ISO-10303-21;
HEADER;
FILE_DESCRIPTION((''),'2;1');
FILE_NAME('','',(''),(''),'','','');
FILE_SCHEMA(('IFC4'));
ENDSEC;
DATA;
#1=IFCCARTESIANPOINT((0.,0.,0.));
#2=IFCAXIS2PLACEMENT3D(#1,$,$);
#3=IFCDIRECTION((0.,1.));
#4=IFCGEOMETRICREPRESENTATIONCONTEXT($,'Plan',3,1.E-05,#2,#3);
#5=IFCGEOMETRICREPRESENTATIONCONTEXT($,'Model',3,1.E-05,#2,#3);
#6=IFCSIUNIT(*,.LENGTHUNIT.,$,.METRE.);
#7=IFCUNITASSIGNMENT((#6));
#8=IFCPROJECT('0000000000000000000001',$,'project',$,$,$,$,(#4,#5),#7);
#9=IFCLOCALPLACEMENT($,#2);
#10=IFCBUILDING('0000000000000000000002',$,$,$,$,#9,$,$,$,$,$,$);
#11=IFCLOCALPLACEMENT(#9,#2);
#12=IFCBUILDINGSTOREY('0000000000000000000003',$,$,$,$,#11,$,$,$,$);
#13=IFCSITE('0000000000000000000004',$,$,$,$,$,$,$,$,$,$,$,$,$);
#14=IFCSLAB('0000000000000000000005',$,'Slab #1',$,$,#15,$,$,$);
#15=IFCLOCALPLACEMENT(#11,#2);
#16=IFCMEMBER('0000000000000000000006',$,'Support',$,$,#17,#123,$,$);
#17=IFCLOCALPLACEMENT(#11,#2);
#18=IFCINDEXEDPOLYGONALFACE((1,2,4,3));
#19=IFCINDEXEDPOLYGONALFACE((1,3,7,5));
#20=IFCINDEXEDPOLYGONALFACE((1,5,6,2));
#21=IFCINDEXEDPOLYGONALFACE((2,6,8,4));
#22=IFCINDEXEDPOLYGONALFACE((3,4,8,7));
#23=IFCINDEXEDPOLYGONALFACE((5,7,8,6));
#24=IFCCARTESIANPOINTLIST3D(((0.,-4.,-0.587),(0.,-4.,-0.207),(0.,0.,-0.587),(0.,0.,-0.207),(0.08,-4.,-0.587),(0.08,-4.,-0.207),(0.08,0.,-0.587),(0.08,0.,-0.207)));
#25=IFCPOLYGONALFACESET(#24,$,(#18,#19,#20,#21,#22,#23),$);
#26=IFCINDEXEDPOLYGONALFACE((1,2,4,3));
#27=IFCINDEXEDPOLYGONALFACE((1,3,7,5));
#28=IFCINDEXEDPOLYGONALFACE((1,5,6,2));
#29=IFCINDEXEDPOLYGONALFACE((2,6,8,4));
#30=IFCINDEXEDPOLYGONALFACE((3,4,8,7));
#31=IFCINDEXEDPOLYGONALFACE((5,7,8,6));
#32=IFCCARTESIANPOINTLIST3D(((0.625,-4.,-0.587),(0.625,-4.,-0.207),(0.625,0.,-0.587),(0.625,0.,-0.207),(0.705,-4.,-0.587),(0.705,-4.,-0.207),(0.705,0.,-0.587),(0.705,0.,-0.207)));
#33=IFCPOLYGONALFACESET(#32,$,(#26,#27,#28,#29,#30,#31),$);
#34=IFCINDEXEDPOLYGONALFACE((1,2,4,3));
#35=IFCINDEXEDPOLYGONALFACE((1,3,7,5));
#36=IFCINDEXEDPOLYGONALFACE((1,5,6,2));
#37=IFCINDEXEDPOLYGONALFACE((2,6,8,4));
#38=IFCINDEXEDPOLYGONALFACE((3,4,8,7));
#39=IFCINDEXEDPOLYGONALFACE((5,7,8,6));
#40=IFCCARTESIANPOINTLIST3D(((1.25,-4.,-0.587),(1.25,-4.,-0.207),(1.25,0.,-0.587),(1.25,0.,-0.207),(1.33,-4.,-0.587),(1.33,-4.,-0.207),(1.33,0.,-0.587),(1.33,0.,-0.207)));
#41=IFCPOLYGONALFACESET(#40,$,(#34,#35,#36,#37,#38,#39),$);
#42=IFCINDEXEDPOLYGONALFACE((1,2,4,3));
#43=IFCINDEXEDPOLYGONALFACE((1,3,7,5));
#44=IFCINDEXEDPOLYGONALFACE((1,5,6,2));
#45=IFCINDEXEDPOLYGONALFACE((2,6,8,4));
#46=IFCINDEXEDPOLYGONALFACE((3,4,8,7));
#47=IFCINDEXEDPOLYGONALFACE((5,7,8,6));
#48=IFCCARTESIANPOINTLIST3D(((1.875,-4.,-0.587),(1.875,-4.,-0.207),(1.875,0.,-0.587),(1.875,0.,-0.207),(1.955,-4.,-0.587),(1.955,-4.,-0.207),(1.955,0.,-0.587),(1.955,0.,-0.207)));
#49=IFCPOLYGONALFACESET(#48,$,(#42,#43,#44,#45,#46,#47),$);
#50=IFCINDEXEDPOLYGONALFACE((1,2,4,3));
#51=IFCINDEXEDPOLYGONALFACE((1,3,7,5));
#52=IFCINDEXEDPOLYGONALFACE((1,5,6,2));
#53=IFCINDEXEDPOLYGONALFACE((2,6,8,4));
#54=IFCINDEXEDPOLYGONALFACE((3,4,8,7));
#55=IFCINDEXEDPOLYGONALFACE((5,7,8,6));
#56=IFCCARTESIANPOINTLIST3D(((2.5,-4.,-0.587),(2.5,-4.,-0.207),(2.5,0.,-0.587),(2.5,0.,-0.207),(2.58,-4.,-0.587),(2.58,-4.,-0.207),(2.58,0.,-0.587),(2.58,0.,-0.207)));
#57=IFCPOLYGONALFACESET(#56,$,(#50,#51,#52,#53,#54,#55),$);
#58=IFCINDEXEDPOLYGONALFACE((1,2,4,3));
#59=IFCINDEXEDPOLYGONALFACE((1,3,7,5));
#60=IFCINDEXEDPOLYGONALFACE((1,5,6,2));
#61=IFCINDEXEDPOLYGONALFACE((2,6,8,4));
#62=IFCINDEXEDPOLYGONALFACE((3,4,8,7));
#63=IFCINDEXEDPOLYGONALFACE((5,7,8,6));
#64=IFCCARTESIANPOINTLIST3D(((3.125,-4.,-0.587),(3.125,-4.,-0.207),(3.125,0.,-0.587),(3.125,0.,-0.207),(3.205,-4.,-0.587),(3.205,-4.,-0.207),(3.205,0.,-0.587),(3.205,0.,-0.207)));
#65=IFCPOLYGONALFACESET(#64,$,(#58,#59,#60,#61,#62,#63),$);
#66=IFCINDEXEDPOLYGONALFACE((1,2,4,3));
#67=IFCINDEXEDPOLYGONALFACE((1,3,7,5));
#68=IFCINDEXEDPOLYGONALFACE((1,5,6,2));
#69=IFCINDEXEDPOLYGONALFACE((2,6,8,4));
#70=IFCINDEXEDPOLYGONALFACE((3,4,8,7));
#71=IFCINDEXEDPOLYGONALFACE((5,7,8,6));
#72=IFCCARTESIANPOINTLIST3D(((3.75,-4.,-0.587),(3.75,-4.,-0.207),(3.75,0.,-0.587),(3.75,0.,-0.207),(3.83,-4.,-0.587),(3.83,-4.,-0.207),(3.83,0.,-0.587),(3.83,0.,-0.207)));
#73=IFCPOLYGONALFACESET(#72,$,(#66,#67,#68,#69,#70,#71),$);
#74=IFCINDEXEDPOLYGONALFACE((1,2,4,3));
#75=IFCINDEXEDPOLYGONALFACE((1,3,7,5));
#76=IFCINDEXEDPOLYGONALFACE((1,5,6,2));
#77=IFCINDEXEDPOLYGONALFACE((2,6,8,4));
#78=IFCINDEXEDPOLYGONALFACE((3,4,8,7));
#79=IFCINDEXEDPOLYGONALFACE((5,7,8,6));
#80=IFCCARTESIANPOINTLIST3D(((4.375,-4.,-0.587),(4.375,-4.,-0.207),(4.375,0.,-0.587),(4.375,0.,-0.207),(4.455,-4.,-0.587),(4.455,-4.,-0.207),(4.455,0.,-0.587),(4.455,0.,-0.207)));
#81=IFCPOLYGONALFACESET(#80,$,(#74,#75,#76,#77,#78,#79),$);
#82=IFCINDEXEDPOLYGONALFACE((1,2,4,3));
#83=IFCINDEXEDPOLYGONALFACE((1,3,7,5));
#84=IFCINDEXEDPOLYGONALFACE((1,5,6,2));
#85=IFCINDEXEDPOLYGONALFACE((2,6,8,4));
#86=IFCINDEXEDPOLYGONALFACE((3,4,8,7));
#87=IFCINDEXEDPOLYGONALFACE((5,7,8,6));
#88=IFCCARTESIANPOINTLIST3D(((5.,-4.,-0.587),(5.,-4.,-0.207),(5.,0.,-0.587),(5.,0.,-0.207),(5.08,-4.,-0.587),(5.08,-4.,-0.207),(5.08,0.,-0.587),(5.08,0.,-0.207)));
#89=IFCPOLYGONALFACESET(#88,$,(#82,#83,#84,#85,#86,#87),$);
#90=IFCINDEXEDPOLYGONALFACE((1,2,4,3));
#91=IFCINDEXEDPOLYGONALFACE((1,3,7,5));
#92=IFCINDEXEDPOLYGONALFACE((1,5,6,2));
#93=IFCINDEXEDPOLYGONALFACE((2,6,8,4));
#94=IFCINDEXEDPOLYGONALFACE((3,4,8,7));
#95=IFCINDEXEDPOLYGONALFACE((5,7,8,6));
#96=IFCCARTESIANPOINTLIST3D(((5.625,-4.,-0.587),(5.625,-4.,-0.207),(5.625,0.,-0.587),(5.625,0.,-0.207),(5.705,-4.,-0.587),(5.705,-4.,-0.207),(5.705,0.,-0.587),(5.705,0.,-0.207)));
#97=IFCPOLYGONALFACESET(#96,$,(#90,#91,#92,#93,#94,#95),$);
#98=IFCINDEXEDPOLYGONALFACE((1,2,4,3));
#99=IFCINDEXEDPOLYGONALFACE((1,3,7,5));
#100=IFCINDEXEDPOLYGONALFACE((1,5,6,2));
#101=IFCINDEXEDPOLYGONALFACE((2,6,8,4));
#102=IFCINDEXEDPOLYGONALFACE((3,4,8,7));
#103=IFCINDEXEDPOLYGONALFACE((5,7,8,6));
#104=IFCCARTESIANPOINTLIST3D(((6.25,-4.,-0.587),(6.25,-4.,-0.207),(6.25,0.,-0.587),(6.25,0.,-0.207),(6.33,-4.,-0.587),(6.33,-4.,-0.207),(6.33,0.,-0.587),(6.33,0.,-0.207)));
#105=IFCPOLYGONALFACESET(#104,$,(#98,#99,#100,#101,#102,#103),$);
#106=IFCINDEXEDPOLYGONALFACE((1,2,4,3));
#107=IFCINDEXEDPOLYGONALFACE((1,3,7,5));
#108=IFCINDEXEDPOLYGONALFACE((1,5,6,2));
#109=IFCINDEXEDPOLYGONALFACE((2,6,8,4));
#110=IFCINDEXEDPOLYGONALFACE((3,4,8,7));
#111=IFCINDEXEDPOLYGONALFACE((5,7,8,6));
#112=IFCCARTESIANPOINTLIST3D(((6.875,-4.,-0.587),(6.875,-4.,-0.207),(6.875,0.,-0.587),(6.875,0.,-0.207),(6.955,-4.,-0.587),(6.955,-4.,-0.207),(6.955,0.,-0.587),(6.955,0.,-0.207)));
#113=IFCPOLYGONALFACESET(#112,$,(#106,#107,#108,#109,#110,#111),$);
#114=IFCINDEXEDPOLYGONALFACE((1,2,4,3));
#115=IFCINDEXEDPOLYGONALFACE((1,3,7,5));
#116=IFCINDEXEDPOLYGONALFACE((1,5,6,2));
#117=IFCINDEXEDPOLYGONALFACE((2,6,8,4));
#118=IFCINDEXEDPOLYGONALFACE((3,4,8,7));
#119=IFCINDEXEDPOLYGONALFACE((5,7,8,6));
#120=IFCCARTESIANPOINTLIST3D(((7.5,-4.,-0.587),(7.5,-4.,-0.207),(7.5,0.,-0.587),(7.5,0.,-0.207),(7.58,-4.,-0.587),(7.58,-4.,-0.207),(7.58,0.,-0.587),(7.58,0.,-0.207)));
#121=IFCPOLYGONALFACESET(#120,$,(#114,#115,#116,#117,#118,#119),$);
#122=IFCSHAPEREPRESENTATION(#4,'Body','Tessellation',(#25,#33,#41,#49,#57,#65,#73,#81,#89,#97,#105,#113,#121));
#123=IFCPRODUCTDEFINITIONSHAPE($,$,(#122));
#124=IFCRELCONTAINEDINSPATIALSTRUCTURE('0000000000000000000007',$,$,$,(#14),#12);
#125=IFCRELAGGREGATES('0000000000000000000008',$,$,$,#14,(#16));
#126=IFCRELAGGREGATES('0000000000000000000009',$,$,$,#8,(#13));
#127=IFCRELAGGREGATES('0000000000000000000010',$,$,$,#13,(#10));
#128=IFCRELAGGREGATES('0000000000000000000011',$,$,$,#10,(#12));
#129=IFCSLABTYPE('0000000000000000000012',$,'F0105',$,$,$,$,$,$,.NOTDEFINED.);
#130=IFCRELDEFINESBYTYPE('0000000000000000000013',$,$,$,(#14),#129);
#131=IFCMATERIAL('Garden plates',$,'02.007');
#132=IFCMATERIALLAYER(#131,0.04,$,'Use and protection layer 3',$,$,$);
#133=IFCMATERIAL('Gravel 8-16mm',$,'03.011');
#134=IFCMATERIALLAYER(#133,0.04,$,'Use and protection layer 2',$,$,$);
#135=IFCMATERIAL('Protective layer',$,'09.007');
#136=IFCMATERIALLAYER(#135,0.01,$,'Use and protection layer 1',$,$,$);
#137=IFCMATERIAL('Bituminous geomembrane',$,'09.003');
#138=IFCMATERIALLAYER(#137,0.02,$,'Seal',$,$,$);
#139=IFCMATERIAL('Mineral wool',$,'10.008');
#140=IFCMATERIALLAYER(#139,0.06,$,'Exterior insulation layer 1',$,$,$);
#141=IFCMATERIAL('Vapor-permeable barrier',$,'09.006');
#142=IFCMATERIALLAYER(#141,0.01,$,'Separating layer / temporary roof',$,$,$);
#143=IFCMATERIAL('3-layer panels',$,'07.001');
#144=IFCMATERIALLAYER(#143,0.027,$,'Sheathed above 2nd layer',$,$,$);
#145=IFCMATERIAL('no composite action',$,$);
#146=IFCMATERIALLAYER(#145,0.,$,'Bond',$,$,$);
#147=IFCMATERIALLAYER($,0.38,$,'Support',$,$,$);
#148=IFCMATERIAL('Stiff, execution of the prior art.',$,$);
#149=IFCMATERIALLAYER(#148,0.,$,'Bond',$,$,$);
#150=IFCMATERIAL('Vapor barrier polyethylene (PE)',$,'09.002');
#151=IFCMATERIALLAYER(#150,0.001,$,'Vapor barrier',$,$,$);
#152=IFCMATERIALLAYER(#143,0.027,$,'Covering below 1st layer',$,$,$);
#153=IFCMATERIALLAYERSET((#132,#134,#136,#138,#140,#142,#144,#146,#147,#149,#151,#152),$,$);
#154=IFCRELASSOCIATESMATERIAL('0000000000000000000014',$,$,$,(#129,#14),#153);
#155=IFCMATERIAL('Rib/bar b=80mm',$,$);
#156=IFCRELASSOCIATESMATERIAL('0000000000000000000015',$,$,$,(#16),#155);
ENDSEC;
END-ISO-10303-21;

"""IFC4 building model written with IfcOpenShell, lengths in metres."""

from ifc_helpers import new_model, si_unit, direction, frame, frame_2d, origin, place, context, project, spatial, rectangle, extrude, material, layer, layer_set, type_object, element, aggregate, save


model = new_model("IFC4")

# Units and contexts
plan_context = context("Plan", 3, precision=1e-05, world=origin(), true_north=direction((0.0, 1.0)))
model_context = context("Model", 3, precision=1e-05, world=origin(), true_north=direction((0.0, 1.0)))
ifc_project = project(units=[si_unit("LENGTHUNIT", "METRE")], contexts=[plan_context, model_context])

# Site, building, storey
site = spatial("IfcSite", under=ifc_project)
building_placement = place(None, origin())
building = spatial("IfcBuilding", under=site, at=building_placement)
storey_placement = place(building_placement, origin())
storey = spatial("IfcBuildingStorey", under=building, at=storey_placement)

# Slab, member
ifc_material_1 = material(Name="Garden plates", Category="02.007")
ifc_layer_1 = layer(ifc_material_1, 0.04, Name="Use and protection layer 3")
ifc_material_2 = material(Name="Gravel 8-16mm", Category="03.011")
ifc_layer_2 = layer(ifc_material_2, 0.04, Name="Use and protection layer 2")
ifc_material_3 = material(Name="Protective layer", Category="09.007")
ifc_layer_3 = layer(ifc_material_3, 0.01, Name="Use and protection layer 1")
ifc_material_4 = material(Name="Bituminous geomembrane", Category="09.003")
ifc_layer_4 = layer(ifc_material_4, 0.02, Name="Seal")
ifc_material_5 = material(Name="Mineral wool", Category="10.008")
ifc_layer_5 = layer(ifc_material_5, 0.06, Name="Exterior insulation layer 1")
ifc_material_6 = material(Name="Vapor-permeable barrier", Category="09.006")
ifc_layer_6 = layer(ifc_material_6, 0.01, Name="Separating layer / temporary roof")
ifc_material_7 = material(Name="3-layer panels", Category="07.001")
ifc_layer_7 = layer(ifc_material_7, 0.027, Name="Sheathed above 2nd layer")
ifc_material_8 = material(Name="no composite action")
ifc_layer_8 = layer(ifc_material_8, 0.0, Name="Bond")
ifc_layer_9 = layer(None, 0.38, Name="Support")
ifc_material_9 = material(Name="Stiff, execution of the prior art.")
ifc_layer_10 = layer(ifc_material_9, 0.0, Name="Bond")
ifc_material_10 = material(Name="Vapor barrier polyethylene (PE)", Category="09.002")
ifc_layer_11 = layer(ifc_material_10, 0.001, Name="Vapor barrier")
ifc_layer_12 = layer(ifc_material_7, 0.027, Name="Covering below 1st layer")
ifc_layer_set = layer_set([ifc_layer_1, ifc_layer_2, ifc_layer_3, ifc_layer_4, ifc_layer_5, ifc_layer_6, ifc_layer_7, ifc_layer_8, ifc_layer_9, ifc_layer_10, ifc_layer_11, ifc_layer_12])
slab_type = type_object("IfcSlabType", Name="F0105", PredefinedType="NOTDEFINED", material=ifc_layer_set)
slab_placement = place(None, frame((0.0, 0.0, 0.0), z_axis=(0.0, 0.0, -1.0), x_axis=(1.0, 0.0, 0.0)))
slab = element("IfcSlab", 1, at=slab_placement, inside=storey, type_object=slab_type, material=ifc_layer_set, Name="Slab #1")
ifc_material_11 = material(Name="Rib/bar b=80mm")
member_1_placement = place(slab_placement, origin())
member_1 = element("IfcMember", 2, at=member_1_placement, material=ifc_material_11, Name="Support", context=plan_context, shape_type="SweptSolid", body=[
    extrude(rectangle(XDim=0.08, YDim=0.38, at=frame_2d((0.04, 0.19), x_axis=(1.0, 0.0))), frame((0.0, 4.0, 0.207), z_axis=(0.0, -1.0, 0.0), x_axis=(1.0, 0.0, 0.0)), (0.0, 0.0, 1.0), 4.0),
    extrude(rectangle(XDim=0.08, YDim=0.38, at=frame_2d((0.04, 0.19), x_axis=(1.0, 0.0))), frame((0.625, 4.0, 0.207), z_axis=(0.0, -1.0, 0.0), x_axis=(1.0, 0.0, 0.0)), (0.0, 0.0, 1.0), 4.0),
    extrude(rectangle(XDim=0.08, YDim=0.38, at=frame_2d((0.04, 0.19), x_axis=(1.0, 0.0))), frame((1.25, 4.0, 0.207), z_axis=(0.0, -1.0, 0.0), x_axis=(1.0, 0.0, 0.0)), (0.0, 0.0, 1.0), 4.0),
    extrude(rectangle(XDim=0.08, YDim=0.38, at=frame_2d((0.04, 0.19), x_axis=(1.0, 0.0))), frame((1.875, 4.0, 0.207), z_axis=(0.0, -1.0, 0.0), x_axis=(1.0, 0.0, 0.0)), (0.0, 0.0, 1.0), 4.0),
    extrude(rectangle(XDim=0.08, YDim=0.38, at=frame_2d((0.04, 0.19), x_axis=(1.0, 0.0))), frame((2.5, 4.0, 0.207), z_axis=(0.0, -1.0, 0.0), x_axis=(1.0, 0.0, 0.0)), (0.0, 0.0, 1.0), 4.0),
    extrude(rectangle(XDim=0.08, YDim=0.38, at=frame_2d((0.04, 0.19), x_axis=(1.0, 0.0))), frame((3.125, 4.0, 0.207), z_axis=(0.0, -1.0, 0.0), x_axis=(1.0, 0.0, 0.0)), (0.0, 0.0, 1.0), 4.0),
    extrude(rectangle(XDim=0.08, YDim=0.38, at=frame_2d((0.04, 0.19), x_axis=(1.0, 0.0))), frame((3.75, 4.0, 0.207), z_axis=(0.0, -1.0, 0.0), x_axis=(1.0, 0.0, 0.0)), (0.0, 0.0, 1.0), 4.0),
    extrude(rectangle(XDim=0.08, YDim=0.38, at=frame_2d((0.04, 0.19), x_axis=(1.0, 0.0))), frame((4.375, 4.0, 0.207), z_axis=(0.0, -1.0, 0.0), x_axis=(1.0, 0.0, 0.0)), (0.0, 0.0, 1.0), 4.0),
    extrude(rectangle(XDim=0.08, YDim=0.38, at=frame_2d((0.04, 0.19), x_axis=(1.0, 0.0))), frame((5.0, 4.0, 0.207), z_axis=(0.0, -1.0, 0.0), x_axis=(1.0, 0.0, 0.0)), (0.0, 0.0, 1.0), 4.0),
    extrude(rectangle(XDim=0.08, YDim=0.38, at=frame_2d((0.04, 0.19), x_axis=(1.0, 0.0))), frame((5.625, 4.0, 0.207), z_axis=(0.0, -1.0, 0.0), x_axis=(1.0, 0.0, 0.0)), (0.0, 0.0, 1.0), 4.0),
    extrude(rectangle(XDim=0.08, YDim=0.38, at=frame_2d((0.04, 0.19), x_axis=(1.0, 0.0))), frame((6.25, 4.0, 0.207), z_axis=(0.0, -1.0, 0.0), x_axis=(1.0, 0.0, 0.0)), (0.0, 0.0, 1.0), 4.0),
    extrude(rectangle(XDim=0.08, YDim=0.38, at=frame_2d((0.04, 0.19), x_axis=(1.0, 0.0))), frame((6.875, 4.0, 0.207), z_axis=(0.0, -1.0, 0.0), x_axis=(1.0, 0.0, 0.0)), (0.0, 0.0, 1.0), 4.0),
    extrude(rectangle(XDim=0.08, YDim=0.38, at=frame_2d((0.04, 0.19), x_axis=(1.0, 0.0))), frame((7.5, 4.0, 0.207), z_axis=(0.0, -1.0, 0.0), x_axis=(1.0, 0.0, 0.0)), (0.0, 0.0, 1.0), 4.0),
])
aggregate(slab, [member_1])

save(model, "model.ifc")
